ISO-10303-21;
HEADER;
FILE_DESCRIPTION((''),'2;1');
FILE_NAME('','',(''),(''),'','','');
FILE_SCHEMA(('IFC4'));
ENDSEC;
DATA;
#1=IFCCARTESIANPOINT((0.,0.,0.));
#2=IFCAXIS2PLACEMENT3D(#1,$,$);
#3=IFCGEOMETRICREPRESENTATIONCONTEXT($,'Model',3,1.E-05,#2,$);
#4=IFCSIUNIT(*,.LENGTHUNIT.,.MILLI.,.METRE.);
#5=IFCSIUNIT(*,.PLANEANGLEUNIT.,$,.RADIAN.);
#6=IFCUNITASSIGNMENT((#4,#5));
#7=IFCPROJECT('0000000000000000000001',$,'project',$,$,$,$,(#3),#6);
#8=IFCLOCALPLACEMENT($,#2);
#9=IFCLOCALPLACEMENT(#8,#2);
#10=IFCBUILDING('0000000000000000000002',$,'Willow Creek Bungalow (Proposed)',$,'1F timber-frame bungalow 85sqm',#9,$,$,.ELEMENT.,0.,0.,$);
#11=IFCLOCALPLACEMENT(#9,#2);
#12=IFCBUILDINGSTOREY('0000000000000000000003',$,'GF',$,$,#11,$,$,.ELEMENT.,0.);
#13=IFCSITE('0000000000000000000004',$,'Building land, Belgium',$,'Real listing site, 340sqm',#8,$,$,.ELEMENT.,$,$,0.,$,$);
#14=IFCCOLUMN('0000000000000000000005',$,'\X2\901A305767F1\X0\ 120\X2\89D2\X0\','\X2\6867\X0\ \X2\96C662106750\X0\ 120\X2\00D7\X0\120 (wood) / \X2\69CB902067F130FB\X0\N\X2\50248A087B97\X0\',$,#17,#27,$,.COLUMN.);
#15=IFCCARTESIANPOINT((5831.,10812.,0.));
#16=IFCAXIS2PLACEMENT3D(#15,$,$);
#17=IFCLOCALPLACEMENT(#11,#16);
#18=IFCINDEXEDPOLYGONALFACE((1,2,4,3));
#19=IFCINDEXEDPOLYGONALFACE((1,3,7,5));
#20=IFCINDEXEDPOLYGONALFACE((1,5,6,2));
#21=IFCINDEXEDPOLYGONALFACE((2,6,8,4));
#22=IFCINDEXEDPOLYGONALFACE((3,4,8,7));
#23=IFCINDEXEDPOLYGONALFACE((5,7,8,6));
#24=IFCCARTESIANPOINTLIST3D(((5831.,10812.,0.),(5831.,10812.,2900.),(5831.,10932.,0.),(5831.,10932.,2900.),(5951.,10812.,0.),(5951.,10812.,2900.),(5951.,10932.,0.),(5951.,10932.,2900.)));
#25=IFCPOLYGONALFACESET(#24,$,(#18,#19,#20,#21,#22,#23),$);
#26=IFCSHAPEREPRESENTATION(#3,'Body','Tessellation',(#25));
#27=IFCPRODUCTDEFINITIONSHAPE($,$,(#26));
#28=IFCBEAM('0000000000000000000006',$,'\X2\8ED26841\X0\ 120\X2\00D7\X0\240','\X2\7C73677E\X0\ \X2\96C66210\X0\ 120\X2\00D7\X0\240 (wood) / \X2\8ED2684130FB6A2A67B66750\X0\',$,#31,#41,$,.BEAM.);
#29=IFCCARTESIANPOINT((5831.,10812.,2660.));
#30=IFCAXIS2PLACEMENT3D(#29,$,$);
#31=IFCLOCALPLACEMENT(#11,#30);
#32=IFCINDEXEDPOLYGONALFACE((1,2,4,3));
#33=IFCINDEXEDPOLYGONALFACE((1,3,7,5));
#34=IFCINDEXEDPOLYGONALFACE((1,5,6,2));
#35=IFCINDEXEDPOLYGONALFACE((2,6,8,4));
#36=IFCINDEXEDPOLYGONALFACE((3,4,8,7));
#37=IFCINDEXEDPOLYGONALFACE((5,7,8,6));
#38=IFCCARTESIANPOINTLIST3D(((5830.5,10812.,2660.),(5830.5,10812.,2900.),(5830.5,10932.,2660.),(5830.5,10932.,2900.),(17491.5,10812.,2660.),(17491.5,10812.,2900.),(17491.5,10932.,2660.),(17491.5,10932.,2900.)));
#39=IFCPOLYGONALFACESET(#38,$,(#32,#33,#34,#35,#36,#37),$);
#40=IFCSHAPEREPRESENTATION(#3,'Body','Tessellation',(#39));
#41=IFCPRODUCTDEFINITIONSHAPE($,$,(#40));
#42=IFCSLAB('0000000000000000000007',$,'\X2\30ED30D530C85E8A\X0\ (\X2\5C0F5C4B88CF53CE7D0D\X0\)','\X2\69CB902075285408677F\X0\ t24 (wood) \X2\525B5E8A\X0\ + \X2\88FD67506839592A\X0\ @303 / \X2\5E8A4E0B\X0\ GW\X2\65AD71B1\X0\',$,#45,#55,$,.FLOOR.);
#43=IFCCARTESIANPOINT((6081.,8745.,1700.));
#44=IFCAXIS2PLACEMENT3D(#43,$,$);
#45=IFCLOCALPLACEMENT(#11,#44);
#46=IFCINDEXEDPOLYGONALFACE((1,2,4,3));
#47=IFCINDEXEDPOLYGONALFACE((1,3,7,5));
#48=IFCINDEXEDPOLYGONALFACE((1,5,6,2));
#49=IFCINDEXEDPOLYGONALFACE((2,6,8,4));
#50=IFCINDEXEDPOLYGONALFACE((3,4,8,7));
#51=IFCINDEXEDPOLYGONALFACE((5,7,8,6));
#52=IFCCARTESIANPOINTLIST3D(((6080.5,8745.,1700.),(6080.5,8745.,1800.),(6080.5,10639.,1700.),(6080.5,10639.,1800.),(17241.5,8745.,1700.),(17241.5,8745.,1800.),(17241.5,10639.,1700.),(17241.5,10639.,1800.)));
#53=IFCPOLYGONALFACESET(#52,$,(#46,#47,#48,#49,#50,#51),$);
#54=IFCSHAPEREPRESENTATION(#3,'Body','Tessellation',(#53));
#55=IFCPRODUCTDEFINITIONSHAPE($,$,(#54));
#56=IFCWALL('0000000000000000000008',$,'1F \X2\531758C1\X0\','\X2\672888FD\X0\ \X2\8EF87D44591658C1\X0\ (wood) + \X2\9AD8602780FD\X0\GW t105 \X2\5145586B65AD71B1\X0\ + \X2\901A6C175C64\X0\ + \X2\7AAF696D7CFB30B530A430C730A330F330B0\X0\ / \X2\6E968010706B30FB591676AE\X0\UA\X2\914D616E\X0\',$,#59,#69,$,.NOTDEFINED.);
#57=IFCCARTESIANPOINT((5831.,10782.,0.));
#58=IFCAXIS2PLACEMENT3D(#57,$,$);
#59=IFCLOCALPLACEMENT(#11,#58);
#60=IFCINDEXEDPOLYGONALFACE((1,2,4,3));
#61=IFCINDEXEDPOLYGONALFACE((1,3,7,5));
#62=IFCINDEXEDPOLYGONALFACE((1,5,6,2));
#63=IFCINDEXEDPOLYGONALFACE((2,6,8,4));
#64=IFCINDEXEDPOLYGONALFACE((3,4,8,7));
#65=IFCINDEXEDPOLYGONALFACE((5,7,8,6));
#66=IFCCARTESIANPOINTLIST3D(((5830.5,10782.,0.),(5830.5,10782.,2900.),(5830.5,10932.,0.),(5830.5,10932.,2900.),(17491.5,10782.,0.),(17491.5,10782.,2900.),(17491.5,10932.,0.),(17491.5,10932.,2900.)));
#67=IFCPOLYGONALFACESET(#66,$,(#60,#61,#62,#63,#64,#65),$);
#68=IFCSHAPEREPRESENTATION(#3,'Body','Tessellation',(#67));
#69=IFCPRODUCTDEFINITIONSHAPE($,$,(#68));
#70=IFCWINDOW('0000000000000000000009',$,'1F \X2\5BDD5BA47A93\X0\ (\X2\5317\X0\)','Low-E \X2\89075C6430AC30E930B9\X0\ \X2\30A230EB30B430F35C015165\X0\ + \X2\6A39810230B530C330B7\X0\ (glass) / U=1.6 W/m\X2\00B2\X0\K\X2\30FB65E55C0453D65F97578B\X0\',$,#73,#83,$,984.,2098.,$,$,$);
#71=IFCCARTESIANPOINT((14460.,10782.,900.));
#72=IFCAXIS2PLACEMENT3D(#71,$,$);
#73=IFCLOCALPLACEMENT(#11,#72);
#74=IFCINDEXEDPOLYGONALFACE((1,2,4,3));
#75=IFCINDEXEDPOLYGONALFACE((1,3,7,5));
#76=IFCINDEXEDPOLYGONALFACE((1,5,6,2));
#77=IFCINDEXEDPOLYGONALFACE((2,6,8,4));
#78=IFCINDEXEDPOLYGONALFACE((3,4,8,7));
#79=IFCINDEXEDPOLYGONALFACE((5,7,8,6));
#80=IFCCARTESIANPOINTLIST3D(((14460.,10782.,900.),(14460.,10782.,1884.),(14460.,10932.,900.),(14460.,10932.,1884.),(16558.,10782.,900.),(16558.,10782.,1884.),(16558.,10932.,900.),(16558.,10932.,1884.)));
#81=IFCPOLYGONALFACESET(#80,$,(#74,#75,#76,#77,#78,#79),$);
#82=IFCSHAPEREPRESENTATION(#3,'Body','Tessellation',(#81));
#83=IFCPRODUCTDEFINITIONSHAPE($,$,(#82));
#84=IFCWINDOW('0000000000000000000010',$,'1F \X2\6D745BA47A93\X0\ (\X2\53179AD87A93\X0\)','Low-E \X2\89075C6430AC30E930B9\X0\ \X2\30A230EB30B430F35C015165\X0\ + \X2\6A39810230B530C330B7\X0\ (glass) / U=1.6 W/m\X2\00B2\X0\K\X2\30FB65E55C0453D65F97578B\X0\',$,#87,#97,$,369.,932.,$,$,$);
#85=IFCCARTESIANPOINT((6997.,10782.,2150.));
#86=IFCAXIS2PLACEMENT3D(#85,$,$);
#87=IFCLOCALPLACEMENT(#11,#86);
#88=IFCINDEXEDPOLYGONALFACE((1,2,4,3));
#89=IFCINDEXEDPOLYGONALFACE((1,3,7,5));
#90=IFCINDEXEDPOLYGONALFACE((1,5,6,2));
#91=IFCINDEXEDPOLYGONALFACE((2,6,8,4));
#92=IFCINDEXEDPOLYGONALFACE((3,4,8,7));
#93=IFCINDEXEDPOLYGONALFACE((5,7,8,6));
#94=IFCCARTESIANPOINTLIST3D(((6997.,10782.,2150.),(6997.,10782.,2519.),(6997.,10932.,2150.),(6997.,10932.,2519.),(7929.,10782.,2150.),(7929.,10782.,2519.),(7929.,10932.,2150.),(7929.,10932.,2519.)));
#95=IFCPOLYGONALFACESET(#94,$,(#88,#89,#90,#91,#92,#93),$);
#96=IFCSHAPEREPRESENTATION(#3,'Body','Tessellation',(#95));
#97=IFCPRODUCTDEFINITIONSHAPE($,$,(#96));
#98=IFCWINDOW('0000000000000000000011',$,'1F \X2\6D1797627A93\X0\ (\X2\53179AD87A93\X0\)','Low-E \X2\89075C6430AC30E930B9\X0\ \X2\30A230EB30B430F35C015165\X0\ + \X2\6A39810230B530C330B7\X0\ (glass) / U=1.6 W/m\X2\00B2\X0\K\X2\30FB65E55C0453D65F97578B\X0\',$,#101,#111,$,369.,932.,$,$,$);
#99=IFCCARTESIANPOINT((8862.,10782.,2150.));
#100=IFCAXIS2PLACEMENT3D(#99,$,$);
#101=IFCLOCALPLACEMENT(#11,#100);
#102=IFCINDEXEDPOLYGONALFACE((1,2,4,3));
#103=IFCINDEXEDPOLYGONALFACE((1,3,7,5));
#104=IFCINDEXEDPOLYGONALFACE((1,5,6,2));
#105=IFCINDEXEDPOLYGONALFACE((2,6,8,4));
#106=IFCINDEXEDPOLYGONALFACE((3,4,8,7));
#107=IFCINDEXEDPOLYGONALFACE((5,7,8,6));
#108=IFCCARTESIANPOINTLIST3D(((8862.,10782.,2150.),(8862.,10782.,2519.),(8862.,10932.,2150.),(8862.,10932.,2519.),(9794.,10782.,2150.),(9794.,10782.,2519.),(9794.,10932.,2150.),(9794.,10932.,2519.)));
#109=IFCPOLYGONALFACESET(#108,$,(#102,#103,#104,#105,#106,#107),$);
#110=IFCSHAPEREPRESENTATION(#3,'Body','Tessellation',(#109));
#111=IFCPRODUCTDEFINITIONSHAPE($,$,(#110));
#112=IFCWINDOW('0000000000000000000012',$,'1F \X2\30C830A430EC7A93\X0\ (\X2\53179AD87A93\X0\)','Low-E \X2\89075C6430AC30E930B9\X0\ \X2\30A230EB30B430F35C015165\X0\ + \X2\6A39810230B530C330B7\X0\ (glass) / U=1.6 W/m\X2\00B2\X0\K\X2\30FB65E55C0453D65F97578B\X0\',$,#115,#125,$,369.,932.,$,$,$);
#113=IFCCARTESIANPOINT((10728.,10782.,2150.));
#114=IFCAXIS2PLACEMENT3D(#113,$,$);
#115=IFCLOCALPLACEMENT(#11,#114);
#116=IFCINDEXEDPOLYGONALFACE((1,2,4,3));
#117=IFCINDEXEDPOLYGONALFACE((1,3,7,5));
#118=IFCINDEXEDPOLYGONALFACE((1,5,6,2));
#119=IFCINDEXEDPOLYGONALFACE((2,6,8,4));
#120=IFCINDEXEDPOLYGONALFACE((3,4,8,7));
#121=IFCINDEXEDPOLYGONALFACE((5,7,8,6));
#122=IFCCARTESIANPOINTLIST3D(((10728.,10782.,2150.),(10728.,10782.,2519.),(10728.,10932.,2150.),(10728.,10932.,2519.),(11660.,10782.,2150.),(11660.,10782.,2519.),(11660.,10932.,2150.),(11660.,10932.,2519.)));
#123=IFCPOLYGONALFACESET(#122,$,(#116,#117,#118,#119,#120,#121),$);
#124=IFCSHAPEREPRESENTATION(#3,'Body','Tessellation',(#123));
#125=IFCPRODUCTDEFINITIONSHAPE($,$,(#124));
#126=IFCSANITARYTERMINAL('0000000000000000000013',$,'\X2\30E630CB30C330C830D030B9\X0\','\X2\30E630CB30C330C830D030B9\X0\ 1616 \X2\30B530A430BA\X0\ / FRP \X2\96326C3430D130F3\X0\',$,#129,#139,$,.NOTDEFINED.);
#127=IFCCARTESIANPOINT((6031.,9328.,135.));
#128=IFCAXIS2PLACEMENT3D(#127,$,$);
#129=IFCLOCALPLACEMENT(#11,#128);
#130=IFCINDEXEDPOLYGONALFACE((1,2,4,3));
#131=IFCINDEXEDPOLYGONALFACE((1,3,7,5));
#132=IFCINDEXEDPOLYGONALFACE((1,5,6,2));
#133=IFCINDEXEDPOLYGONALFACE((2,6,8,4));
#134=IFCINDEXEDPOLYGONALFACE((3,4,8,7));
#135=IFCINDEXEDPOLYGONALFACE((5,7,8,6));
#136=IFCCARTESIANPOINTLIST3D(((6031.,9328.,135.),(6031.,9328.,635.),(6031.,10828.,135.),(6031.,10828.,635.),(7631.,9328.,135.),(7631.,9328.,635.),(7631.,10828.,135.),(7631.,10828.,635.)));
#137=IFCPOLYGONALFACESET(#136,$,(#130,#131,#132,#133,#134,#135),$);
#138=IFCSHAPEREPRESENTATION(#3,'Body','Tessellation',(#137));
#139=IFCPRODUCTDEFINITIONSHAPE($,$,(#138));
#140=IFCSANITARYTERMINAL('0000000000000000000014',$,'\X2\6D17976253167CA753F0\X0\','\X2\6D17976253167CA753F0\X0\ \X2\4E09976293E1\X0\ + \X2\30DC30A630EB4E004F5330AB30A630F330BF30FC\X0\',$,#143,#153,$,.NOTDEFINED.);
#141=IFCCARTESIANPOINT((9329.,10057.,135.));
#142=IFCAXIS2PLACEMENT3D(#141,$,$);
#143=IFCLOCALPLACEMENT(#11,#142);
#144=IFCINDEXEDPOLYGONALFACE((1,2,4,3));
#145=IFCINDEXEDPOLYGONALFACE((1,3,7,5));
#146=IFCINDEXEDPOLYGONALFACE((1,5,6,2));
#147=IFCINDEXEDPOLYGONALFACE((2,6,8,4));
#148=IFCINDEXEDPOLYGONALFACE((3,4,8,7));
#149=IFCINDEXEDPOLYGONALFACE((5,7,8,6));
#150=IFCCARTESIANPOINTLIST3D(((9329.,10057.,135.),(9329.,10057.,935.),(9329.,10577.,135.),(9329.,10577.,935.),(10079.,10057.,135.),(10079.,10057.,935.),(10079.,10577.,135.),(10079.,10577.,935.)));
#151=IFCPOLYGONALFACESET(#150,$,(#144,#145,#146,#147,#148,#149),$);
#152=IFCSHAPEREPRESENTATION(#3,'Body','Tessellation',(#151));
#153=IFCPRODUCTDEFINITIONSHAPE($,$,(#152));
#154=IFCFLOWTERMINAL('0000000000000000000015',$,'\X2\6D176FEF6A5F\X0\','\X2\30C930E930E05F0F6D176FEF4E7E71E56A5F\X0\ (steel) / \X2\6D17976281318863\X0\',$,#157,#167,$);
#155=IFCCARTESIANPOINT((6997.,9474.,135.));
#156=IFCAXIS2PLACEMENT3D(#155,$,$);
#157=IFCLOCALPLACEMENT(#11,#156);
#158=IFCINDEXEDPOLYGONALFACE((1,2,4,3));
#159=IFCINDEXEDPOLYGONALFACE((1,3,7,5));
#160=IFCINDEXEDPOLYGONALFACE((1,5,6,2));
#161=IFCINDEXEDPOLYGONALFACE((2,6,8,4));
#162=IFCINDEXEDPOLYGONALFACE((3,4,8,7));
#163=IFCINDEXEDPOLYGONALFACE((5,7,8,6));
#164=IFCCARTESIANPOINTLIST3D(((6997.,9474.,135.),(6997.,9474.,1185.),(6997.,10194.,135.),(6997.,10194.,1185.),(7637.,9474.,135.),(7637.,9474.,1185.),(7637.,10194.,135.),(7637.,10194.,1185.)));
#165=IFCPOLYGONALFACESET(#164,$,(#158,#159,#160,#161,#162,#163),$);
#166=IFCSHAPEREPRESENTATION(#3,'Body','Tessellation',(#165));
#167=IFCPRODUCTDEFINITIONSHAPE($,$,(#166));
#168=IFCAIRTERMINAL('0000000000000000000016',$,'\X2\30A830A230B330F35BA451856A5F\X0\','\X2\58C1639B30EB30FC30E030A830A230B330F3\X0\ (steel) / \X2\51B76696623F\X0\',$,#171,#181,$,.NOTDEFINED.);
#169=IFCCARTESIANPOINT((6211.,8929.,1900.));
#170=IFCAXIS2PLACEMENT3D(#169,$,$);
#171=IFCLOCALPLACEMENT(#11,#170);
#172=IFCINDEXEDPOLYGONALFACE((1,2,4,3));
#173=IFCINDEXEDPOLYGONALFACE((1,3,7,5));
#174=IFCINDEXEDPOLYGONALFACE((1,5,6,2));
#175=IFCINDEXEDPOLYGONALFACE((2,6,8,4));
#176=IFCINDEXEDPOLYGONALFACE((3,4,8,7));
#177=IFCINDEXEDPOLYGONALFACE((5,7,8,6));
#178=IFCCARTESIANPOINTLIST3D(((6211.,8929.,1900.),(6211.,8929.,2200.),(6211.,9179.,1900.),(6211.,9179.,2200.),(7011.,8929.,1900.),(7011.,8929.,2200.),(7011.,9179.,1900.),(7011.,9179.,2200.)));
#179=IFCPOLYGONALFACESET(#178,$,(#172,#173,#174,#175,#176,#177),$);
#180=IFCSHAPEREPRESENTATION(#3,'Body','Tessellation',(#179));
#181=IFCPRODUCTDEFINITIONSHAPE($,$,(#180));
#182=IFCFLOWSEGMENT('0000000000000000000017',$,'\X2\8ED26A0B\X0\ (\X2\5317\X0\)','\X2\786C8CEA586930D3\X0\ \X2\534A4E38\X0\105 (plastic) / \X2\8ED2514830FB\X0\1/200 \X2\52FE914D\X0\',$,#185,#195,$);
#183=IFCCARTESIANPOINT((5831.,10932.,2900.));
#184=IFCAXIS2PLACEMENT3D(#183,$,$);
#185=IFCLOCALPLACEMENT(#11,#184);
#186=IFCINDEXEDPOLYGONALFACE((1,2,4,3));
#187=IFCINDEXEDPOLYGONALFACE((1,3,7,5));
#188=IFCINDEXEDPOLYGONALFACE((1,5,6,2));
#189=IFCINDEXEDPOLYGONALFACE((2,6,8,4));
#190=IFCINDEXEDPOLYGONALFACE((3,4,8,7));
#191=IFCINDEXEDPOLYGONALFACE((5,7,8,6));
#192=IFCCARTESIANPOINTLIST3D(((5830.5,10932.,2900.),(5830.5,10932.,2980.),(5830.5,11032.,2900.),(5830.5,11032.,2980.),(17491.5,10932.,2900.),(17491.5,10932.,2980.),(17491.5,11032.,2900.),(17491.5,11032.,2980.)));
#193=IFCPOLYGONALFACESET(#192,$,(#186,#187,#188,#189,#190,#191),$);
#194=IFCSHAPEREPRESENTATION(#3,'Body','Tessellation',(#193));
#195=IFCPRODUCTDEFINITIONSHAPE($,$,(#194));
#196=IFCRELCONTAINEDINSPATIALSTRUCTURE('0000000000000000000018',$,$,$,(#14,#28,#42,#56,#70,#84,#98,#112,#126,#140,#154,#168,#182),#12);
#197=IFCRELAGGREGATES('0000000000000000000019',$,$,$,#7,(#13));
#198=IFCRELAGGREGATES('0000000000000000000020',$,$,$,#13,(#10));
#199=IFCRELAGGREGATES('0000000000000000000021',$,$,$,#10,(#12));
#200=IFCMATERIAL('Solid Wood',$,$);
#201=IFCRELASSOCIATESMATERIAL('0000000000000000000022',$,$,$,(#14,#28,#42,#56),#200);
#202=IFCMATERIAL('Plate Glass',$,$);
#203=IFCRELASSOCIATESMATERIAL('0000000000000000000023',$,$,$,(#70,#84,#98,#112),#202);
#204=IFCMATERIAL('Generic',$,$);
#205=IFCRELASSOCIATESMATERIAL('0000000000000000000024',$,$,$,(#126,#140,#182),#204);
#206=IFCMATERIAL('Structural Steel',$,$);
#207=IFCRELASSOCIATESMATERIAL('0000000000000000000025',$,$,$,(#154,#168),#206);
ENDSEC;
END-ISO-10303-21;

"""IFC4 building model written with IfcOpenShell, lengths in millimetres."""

from ifc_helpers import new_model, si_unit, frame, frame_2d, origin, place, context, project, spatial, rectangle, extrude, material, element, fill, save


model = new_model("IFC4")

# Units and contexts
model_context = context("Model", 3, precision=1e-05, world=origin())
ifc_project = project(units=[si_unit("LENGTHUNIT", "METRE", prefix="MILLI"), si_unit("PLANEANGLEUNIT", "RADIAN")], contexts=[model_context])

# Site, building, storey
site_placement = place(None, origin())
site = spatial("IfcSite", under=ifc_project, at=site_placement, Name="Building land, Belgium", ObjectType="Real listing site, 340sqm", CompositionType="ELEMENT", RefElevation=0.0)
building_placement = place(site_placement, origin())
building = spatial("IfcBuilding", under=site, at=building_placement, Name="Willow Creek Bungalow (Proposed)", ObjectType="1F timber-frame bungalow 85sqm", CompositionType="ELEMENT", ElevationOfRefHeight=0.0, ElevationOfTerrain=0.0)
storey_placement = place(building_placement, origin())
storey = spatial("IfcBuildingStorey", under=building, at=storey_placement, Name="GF", CompositionType="ELEMENT", Elevation=0.0)

# Column
ifc_material_1 = material(Name="Solid Wood")
column_1_placement = place(storey_placement, frame((5831.0, 10812.0, 0.0)))
element("IfcColumn", 1, at=column_1_placement, inside=storey, material=ifc_material_1, Name="通し柱 120角", Description="桧 集成材 120×120 (wood) / 構造柱・N値計算", PredefinedType="COLUMN", context=model_context, shape_type="SweptSolid", body=[
    extrude(rectangle(XDim=120.0, YDim=120.0, at=frame_2d((60.0, 60.0))), frame((5831.0, 10812.0, 0.0)), (0.0, 0.0, 1.0), 2900.0),
])

# Beam
beam_1_placement = place(storey_placement, frame((5831.0, 10812.0, 2660.0)))
element("IfcBeam", 2, at=beam_1_placement, inside=storey, material=ifc_material_1, Name="軒桁 120×240", Description="米松 集成 120×240 (wood) / 軒桁・横架材", PredefinedType="BEAM", context=model_context, shape_type="SweptSolid", body=[
    extrude(rectangle(XDim=11661.0, YDim=120.0, at=frame_2d((5830.0, 60.0))), frame((5831.0, 10812.0, 2660.0)), (0.0, 0.0, 1.0), 240.0),
])

# Slab
slab_placement = place(storey_placement, frame((6081.0, 8745.0, 1700.0)))
element("IfcSlab", 3, at=slab_placement, inside=storey, material=ifc_material_1, Name="ロフト床 (小屋裏収納)", Description="構造用合板 t24 (wood) 剛床 + 製材根太 @303 / 床下 GW断熱", PredefinedType="FLOOR", context=model_context, shape_type="SweptSolid", body=[
    extrude(rectangle(XDim=11161.0, YDim=1894.0, at=frame_2d((5580.0, 947.0))), frame((6081.0, 8745.0, 1700.0)), (0.0, 0.0, 1.0), 100.0),
])

# Wall, openings, windows
wall_1_placement = place(storey_placement, frame((5831.0, 10782.0, 0.0)))
wall_1 = element("IfcWall", 4, at=wall_1_placement, inside=storey, material=ifc_material_1, Name="1F 北壁", Description="木製 軸組外壁 (wood) + 高性能GW t105 充填断熱 + 通気層 + 窯業系サイディング / 準耐火・外皮UA配慮", PredefinedType="NOTDEFINED", context=model_context, shape_type="SweptSolid", body=[
    extrude(rectangle(XDim=11661.0, YDim=150.0, at=frame_2d((5830.0, 75.0))), frame((5831.0, 10782.0, 0.0)), (0.0, 0.0, 1.0), 2900.0),
])
opening_1_placement = place(storey_placement, frame((14460.0, 10782.0, 900.0)))
opening_1 = element("IfcOpeningElement", 5, at=opening_1_placement, cuts=wall_1, PredefinedType="NOTDEFINED", context=model_context, shape_type="SweptSolid", body=[
    extrude(rectangle(XDim=2098.0, YDim=150.0, at=frame_2d((1049.0, 75.0))), frame((14460.0, 10782.0, 900.0)), (0.0, 0.0, 1.0), 984.0),
])
opening_2_placement = place(storey_placement, frame((6997.0, 10782.0, 2150.0)))
opening_2 = element("IfcOpeningElement", 6, at=opening_2_placement, cuts=wall_1, PredefinedType="NOTDEFINED", context=model_context, shape_type="SweptSolid", body=[
    extrude(rectangle(XDim=932.0, YDim=150.0, at=frame_2d((466.0, 75.0))), frame((6997.0, 10782.0, 2150.0)), (0.0, 0.0, 1.0), 369.0),
])
opening_3_placement = place(storey_placement, frame((8862.0, 10782.0, 2150.0)))
opening_3 = element("IfcOpeningElement", 7, at=opening_3_placement, cuts=wall_1, PredefinedType="NOTDEFINED", context=model_context, shape_type="SweptSolid", body=[
    extrude(rectangle(XDim=932.0, YDim=150.0, at=frame_2d((466.0, 75.0))), frame((8862.0, 10782.0, 2150.0)), (0.0, 0.0, 1.0), 369.0),
])
opening_4_placement = place(storey_placement, frame((10728.0, 10782.0, 2150.0)))
opening_4 = element("IfcOpeningElement", 8, at=opening_4_placement, cuts=wall_1, PredefinedType="NOTDEFINED", context=model_context, shape_type="SweptSolid", body=[
    extrude(rectangle(XDim=932.0, YDim=150.0, at=frame_2d((466.0, 75.0))), frame((10728.0, 10782.0, 2150.0)), (0.0, 0.0, 1.0), 369.0),
])
ifc_material_2 = material(Name="Plate Glass")
window_1_placement = place(storey_placement, frame((14460.0, 10782.0, 900.0)))
window_1 = element("IfcWindow", 9, at=window_1_placement, inside=storey, material=ifc_material_2, Name="1F 寝室窓 (北)", Description="Low-E 複層ガラス アルゴン封入 + 樹脂サッシ (glass) / U=1.6 W/m²K・日射取得型", OverallHeight=984.0, OverallWidth=2098.0, context=model_context, shape_type="SweptSolid", body=[
    extrude(rectangle(XDim=2098.0, YDim=150.0, at=frame_2d((1049.0, 75.0))), frame((14460.0, 10782.0, 900.0)), (0.0, 0.0, 1.0), 984.0),
])
fill(opening_1, window_1)
window_2_placement = place(storey_placement, frame((6997.0, 10782.0, 2150.0)))
window_2 = element("IfcWindow", 10, at=window_2_placement, inside=storey, material=ifc_material_2, Name="1F 浴室窓 (北高窓)", Description="Low-E 複層ガラス アルゴン封入 + 樹脂サッシ (glass) / U=1.6 W/m²K・日射取得型", OverallHeight=369.0, OverallWidth=932.0, context=model_context, shape_type="SweptSolid", body=[
    extrude(rectangle(XDim=932.0, YDim=150.0, at=frame_2d((466.0, 75.0))), frame((6997.0, 10782.0, 2150.0)), (0.0, 0.0, 1.0), 369.0),
])
fill(opening_2, window_2)
window_3_placement = place(storey_placement, frame((8862.0, 10782.0, 2150.0)))
window_3 = element("IfcWindow", 11, at=window_3_placement, inside=storey, material=ifc_material_2, Name="1F 洗面窓 (北高窓)", Description="Low-E 複層ガラス アルゴン封入 + 樹脂サッシ (glass) / U=1.6 W/m²K・日射取得型", OverallHeight=369.0, OverallWidth=932.0, context=model_context, shape_type="SweptSolid", body=[
    extrude(rectangle(XDim=932.0, YDim=150.0, at=frame_2d((466.0, 75.0))), frame((8862.0, 10782.0, 2150.0)), (0.0, 0.0, 1.0), 369.0),
])
fill(opening_3, window_3)
window_4_placement = place(storey_placement, frame((10728.0, 10782.0, 2150.0)))
window_4 = element("IfcWindow", 12, at=window_4_placement, inside=storey, material=ifc_material_2, Name="1F トイレ窓 (北高窓)", Description="Low-E 複層ガラス アルゴン封入 + 樹脂サッシ (glass) / U=1.6 W/m²K・日射取得型", OverallHeight=369.0, OverallWidth=932.0, context=model_context, shape_type="SweptSolid", body=[
    extrude(rectangle(XDim=932.0, YDim=150.0, at=frame_2d((466.0, 75.0))), frame((10728.0, 10782.0, 2150.0)), (0.0, 0.0, 1.0), 369.0),
])
fill(opening_4, window_4)

# Shared definitions
ifc_material_3 = material(Name="Generic")

# Sanitary terminals
sanitary_terminal_1_placement = place(storey_placement, frame((6031.0, 9328.0, 135.0)))
element("IfcSanitaryTerminal", 13, at=sanitary_terminal_1_placement, inside=storey, material=ifc_material_3, Name="ユニットバス", Description="ユニットバス 1616 サイズ / FRP 防水パン", PredefinedType="NOTDEFINED", context=model_context, shape_type="SweptSolid", body=[
    extrude(rectangle(XDim=1600.0, YDim=1500.0, at=frame_2d((800.0, 750.0))), frame((6031.0, 9328.0, 135.0)), (0.0, 0.0, 1.0), 500.0),
])
sanitary_terminal_2_placement = place(storey_placement, frame((9329.0, 10057.0, 135.0)))
element("IfcSanitaryTerminal", 14, at=sanitary_terminal_2_placement, inside=storey, material=ifc_material_3, Name="洗面化粧台", Description="洗面化粧台 三面鏡 + ボウル一体カウンター", PredefinedType="NOTDEFINED", context=model_context, shape_type="SweptSolid", body=[
    extrude(rectangle(XDim=750.0, YDim=520.0, at=frame_2d((375.0, 260.0))), frame((9329.0, 10057.0, 135.0)), (0.0, 0.0, 1.0), 800.0),
])

# Flow terminal
ifc_material_4 = material(Name="Structural Steel")
flow_terminal_placement = place(storey_placement, frame((6997.0, 9474.0, 135.0)))
element("IfcFlowTerminal", 15, at=flow_terminal_placement, inside=storey, material=ifc_material_4, Name="洗濯機", Description="ドラム式洗濯乾燥機 (steel) / 洗面脱衣", context=model_context, shape_type="SweptSolid", body=[
    extrude(rectangle(XDim=640.0, YDim=720.0, at=frame_2d((320.0, 360.0))), frame((6997.0, 9474.0, 135.0)), (0.0, 0.0, 1.0), 1050.0),
])

# Air terminal
air_terminal_placement = place(storey_placement, frame((6211.0, 8929.0, 1900.0)))
element("IfcAirTerminal", 16, at=air_terminal_placement, inside=storey, material=ifc_material_4, Name="エアコン室内機", Description="壁掛ルームエアコン (steel) / 冷暖房", PredefinedType="NOTDEFINED", context=model_context, shape_type="SweptSolid", body=[
    extrude(rectangle(XDim=800.0, YDim=250.0, at=frame_2d((400.0, 125.0))), frame((6211.0, 8929.0, 1900.0)), (0.0, 0.0, 1.0), 300.0),
])

# Flow segment
flow_segment_1_placement = place(storey_placement, frame((5831.0, 10932.0, 2900.0)))
element("IfcFlowSegment", 17, at=flow_segment_1_placement, inside=storey, material=ifc_material_3, Name="軒樋 (北)", Description="硬質塩ビ 半丸105 (plastic) / 軒先・1/200 勾配", context=model_context, shape_type="SweptSolid", body=[
    extrude(rectangle(XDim=11661.0, YDim=100.0, at=frame_2d((5830.0, 50.0))), frame((5831.0, 10932.0, 2900.0)), (0.0, 0.0, 1.0), 80.0),
])

save(model, "model.ifc")
